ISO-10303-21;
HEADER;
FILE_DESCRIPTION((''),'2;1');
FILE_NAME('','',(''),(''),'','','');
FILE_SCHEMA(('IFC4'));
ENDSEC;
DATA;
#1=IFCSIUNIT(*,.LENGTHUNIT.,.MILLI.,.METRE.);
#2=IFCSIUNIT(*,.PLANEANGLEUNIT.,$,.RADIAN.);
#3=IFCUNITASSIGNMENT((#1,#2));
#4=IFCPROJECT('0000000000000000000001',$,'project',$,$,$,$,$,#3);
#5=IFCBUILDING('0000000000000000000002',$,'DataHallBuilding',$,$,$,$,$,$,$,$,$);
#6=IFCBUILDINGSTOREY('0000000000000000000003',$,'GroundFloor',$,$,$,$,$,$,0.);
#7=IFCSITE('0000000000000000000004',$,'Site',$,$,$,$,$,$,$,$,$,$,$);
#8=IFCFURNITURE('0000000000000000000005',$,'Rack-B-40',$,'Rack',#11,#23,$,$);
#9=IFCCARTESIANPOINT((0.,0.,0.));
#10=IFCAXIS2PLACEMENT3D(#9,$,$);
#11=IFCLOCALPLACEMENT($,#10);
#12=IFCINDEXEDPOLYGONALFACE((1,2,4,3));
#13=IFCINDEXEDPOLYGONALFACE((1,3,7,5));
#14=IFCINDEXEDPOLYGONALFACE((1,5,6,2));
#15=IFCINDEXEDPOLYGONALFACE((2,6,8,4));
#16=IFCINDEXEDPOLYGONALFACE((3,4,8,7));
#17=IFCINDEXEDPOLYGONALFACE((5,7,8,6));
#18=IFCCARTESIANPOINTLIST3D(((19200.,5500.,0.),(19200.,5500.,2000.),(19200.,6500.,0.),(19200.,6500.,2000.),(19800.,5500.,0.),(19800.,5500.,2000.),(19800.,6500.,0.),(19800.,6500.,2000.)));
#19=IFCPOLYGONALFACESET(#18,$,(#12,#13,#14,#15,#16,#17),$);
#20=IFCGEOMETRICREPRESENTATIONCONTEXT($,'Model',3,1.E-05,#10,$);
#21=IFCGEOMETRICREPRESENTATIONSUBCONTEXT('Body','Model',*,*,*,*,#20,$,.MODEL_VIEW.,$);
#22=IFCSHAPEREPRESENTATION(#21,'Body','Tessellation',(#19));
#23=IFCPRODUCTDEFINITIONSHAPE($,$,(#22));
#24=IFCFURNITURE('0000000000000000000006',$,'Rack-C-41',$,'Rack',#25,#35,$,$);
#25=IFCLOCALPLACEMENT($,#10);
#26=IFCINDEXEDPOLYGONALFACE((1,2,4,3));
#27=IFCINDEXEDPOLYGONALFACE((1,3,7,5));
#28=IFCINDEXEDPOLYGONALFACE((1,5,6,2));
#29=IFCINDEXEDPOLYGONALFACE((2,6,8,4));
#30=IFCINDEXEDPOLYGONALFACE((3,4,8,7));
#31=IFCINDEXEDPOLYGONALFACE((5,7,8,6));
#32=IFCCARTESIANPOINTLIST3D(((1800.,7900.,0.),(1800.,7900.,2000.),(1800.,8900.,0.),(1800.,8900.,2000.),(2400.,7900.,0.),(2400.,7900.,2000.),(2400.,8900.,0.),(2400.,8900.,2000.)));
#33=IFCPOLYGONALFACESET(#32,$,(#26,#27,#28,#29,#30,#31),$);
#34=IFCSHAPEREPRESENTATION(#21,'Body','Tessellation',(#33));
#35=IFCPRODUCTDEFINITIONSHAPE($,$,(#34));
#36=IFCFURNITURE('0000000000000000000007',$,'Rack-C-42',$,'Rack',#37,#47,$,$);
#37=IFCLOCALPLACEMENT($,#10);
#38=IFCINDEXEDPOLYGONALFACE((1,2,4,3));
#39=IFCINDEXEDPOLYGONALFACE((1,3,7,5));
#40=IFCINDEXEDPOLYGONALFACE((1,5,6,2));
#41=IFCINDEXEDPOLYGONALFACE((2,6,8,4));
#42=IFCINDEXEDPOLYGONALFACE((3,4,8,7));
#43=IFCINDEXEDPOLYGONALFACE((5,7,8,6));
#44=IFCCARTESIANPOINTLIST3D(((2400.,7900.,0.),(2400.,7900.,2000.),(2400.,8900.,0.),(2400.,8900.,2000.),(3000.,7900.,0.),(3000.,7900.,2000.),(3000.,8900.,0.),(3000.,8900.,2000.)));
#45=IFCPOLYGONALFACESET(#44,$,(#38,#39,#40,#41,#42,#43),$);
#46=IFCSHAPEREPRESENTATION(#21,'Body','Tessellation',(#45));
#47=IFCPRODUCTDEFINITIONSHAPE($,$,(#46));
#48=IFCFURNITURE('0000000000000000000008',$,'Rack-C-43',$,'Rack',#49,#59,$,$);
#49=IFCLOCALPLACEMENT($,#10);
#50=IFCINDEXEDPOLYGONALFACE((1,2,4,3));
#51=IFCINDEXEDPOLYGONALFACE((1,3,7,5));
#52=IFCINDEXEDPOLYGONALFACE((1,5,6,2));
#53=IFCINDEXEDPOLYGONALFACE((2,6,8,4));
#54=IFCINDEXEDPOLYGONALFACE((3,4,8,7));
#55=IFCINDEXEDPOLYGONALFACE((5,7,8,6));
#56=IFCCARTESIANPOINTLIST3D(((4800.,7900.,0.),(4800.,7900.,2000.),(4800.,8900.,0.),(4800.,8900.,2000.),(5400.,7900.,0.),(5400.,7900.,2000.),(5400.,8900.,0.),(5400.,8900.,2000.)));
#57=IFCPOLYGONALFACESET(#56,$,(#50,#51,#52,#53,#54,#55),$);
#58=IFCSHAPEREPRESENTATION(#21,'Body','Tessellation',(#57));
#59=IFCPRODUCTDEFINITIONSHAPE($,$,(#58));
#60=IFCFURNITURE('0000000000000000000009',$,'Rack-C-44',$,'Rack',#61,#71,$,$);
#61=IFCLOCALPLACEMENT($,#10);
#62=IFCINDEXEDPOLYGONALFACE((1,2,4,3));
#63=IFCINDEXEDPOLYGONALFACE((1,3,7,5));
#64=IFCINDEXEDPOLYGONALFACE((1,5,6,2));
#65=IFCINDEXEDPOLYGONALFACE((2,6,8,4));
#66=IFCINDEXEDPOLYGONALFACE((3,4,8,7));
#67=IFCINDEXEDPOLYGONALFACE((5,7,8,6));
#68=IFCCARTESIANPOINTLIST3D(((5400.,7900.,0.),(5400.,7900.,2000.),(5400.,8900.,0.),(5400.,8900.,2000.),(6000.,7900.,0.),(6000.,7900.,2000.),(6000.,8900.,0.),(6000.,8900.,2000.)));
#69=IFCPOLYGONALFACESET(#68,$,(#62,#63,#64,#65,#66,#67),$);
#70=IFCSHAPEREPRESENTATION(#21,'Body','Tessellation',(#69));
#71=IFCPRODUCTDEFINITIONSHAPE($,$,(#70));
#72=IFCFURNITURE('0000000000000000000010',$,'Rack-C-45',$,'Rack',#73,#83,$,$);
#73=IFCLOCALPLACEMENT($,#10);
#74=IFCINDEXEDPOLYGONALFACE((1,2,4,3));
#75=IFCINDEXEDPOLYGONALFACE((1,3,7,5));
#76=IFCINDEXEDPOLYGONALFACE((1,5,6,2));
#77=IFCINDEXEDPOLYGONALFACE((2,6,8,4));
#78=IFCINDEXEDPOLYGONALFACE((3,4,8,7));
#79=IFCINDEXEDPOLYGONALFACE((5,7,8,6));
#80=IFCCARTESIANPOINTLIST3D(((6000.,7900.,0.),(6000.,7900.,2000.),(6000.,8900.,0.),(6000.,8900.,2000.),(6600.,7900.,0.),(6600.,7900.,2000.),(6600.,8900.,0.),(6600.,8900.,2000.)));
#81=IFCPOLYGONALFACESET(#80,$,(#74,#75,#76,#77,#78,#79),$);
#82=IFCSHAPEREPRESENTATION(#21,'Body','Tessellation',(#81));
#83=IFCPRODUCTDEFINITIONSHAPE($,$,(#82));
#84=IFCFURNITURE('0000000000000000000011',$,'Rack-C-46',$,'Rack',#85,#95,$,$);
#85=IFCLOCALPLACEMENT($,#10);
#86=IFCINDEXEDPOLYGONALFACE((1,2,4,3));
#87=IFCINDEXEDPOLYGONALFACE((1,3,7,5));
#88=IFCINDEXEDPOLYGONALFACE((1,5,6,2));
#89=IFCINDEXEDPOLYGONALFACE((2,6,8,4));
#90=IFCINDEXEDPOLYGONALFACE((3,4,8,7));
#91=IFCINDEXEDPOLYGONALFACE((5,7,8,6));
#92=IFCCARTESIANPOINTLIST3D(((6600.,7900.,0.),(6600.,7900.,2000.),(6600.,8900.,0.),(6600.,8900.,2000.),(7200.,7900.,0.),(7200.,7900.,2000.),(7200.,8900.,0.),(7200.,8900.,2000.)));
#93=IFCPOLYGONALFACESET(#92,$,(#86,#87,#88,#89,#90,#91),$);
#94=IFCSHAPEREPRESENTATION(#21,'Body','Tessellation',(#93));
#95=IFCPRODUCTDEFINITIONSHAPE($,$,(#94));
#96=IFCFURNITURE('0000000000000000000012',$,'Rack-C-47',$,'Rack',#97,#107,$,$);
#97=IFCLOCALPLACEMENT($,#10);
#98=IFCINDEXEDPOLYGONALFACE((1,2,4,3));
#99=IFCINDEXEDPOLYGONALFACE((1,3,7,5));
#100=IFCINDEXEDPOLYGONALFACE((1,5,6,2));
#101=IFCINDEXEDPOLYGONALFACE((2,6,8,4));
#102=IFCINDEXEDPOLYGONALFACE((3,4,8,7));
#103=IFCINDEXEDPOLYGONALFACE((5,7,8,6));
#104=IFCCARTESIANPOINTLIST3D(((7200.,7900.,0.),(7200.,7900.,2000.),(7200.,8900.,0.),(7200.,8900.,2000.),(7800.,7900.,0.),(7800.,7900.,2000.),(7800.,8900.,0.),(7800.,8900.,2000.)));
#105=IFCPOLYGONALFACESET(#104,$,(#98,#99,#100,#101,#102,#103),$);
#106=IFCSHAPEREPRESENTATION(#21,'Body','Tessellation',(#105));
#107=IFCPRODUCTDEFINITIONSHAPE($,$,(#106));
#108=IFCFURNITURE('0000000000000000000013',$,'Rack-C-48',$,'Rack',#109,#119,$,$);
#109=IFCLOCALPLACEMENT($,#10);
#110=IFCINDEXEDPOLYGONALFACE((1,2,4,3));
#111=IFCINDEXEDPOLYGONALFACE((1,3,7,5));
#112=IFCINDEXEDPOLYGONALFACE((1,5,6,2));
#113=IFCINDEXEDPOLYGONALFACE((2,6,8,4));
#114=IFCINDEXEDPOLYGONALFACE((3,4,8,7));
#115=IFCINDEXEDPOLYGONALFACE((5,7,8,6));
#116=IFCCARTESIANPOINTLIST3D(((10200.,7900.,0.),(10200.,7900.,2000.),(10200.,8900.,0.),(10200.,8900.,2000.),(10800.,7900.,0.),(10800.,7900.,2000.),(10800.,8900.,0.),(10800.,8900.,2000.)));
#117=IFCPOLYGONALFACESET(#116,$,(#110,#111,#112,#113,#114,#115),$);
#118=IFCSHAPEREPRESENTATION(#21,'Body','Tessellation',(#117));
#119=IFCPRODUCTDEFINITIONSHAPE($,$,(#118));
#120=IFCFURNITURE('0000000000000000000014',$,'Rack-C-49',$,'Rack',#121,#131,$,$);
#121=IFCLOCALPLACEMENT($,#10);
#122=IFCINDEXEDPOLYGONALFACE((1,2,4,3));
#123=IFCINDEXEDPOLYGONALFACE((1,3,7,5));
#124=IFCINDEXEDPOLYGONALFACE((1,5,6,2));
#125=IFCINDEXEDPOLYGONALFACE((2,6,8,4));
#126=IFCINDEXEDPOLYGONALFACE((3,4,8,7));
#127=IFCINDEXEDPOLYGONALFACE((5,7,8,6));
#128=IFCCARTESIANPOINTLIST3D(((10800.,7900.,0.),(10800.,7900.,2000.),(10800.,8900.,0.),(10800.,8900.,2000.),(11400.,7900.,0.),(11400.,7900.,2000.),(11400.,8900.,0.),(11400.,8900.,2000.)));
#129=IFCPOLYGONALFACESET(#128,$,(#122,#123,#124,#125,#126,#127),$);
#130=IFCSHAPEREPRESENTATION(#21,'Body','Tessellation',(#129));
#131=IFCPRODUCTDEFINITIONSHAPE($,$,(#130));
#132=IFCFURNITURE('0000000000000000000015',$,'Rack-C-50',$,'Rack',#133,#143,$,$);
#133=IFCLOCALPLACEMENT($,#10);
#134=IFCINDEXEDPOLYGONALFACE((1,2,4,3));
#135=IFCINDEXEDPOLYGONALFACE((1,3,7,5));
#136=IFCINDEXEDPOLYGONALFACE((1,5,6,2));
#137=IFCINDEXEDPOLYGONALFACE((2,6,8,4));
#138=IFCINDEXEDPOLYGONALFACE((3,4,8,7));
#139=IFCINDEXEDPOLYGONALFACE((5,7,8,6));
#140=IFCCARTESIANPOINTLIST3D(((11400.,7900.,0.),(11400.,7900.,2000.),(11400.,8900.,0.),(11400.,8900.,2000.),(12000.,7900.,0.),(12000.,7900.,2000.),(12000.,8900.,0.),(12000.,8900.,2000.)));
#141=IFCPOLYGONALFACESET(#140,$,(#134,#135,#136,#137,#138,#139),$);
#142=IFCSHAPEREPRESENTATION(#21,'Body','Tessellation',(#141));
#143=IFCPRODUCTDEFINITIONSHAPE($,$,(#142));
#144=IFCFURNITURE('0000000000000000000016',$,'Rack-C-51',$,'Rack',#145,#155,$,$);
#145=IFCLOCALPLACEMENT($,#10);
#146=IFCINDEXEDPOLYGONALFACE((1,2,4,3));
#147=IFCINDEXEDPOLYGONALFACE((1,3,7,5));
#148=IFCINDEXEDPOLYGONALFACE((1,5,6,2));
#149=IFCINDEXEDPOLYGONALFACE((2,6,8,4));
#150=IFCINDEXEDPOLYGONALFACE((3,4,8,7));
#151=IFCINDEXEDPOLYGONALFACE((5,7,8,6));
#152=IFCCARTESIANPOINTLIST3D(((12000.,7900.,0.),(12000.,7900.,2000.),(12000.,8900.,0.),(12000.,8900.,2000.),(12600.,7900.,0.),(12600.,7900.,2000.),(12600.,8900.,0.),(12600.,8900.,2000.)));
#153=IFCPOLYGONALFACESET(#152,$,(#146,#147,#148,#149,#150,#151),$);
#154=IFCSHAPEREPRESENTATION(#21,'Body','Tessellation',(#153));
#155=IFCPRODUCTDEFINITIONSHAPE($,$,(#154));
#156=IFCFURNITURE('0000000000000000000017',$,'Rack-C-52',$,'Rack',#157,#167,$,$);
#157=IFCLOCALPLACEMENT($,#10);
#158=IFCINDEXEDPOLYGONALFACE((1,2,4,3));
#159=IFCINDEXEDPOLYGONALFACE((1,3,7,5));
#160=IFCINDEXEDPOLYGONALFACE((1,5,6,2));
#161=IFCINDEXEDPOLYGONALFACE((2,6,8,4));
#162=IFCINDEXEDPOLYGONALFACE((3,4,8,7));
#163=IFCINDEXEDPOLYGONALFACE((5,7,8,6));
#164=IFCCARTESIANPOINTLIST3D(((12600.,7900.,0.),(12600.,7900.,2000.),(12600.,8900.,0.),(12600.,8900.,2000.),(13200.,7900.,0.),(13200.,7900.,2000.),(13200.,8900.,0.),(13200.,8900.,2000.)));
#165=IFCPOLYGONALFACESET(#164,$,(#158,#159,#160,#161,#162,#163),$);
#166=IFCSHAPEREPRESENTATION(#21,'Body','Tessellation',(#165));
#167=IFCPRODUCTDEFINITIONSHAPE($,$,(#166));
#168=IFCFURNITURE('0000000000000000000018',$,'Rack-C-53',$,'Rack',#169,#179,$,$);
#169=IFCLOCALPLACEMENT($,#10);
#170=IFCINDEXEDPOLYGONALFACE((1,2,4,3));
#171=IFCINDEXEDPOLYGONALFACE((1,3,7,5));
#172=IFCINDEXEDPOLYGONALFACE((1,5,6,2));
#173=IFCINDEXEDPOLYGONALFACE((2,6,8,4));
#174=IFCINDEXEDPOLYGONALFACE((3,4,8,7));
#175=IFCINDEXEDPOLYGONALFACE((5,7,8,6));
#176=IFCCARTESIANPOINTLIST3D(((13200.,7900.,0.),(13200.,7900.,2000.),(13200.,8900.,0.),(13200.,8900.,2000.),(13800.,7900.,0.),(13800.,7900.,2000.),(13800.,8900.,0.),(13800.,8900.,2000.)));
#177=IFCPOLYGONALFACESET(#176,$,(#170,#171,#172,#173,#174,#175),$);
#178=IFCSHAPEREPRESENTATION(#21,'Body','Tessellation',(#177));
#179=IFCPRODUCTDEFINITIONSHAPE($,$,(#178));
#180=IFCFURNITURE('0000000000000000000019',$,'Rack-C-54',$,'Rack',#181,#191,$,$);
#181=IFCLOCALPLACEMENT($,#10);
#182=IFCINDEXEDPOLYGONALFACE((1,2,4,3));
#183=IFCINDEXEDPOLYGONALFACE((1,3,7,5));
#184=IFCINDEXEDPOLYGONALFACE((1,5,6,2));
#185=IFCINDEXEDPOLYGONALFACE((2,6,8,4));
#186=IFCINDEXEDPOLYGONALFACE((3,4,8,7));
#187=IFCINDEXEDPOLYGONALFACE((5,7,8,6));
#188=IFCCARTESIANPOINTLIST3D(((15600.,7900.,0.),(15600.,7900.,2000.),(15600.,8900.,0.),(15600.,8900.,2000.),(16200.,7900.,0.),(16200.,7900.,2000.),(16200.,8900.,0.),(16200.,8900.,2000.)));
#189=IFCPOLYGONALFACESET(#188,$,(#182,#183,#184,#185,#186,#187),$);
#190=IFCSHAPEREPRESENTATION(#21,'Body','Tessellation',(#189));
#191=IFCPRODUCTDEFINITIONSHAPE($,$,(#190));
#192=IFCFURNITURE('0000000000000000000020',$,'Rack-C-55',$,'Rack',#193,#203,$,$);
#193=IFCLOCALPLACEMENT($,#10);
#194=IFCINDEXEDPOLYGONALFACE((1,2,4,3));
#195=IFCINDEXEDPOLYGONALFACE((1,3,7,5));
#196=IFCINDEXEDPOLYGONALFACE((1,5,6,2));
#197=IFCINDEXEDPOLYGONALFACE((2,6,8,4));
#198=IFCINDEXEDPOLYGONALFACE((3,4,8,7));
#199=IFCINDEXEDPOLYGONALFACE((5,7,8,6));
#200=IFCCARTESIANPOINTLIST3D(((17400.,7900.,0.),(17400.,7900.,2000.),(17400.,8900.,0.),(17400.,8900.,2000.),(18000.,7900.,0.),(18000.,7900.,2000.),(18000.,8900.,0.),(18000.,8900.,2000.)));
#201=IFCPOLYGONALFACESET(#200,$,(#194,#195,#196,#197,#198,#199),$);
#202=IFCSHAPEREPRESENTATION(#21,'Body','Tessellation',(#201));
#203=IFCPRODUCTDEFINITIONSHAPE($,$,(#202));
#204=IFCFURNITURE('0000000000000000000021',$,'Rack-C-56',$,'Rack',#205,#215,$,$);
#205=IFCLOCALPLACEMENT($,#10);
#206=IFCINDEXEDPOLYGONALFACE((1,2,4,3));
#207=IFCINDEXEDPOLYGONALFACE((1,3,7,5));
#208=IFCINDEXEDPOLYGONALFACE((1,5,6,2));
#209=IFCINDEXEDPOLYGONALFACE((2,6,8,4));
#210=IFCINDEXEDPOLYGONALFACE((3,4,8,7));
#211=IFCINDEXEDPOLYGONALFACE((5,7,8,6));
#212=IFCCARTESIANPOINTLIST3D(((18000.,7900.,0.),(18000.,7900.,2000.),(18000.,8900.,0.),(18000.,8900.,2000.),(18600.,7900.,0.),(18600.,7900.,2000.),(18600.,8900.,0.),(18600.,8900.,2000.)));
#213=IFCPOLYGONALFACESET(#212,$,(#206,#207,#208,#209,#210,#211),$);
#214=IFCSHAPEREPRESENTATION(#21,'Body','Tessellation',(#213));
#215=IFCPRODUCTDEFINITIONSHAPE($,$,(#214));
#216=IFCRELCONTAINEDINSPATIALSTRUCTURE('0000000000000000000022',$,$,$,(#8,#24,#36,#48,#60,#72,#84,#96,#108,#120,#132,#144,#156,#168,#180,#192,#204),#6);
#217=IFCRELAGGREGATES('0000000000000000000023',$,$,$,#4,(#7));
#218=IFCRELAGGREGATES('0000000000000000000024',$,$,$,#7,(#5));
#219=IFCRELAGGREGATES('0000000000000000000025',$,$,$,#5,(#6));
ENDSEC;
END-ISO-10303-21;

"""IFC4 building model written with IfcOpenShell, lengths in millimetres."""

from ifc_helpers import new_model, si_unit, frame, origin, place, context, subcontext, project, spatial, rectangle, extrude, element, save


model = new_model("IFC4")

# Units and contexts
model_context = context("Model", 3, precision=1e-05, world=origin())
body_context = subcontext(model_context, "Body", "Model", "MODEL_VIEW")
ifc_project = project(units=[si_unit("LENGTHUNIT", "METRE", prefix="MILLI"), si_unit("PLANEANGLEUNIT", "RADIAN")])

# Site, building, storey
site = spatial("IfcSite", under=ifc_project, Name="Site")
building = spatial("IfcBuilding", under=site, Name="DataHallBuilding")
storey = spatial("IfcBuildingStorey", under=building, Name="GroundFloor", Elevation=0.0)

# Furniture
furniture_1_placement = place(None, origin())
element("IfcFurniture", 1, at=furniture_1_placement, inside=storey, Name="Rack-B-40", ObjectType="Rack", context=body_context, shape_type="SweptSolid", body=[
    extrude(rectangle(XDim=600.0, YDim=1000.0), frame((19500.0, 6000.0, 0.0), z_axis=(0.0, 0.0, 1.0), x_axis=(1.0, 0.0, 0.0)), (0.0, 0.0, 1.0), 2000.0),
])
furniture_2_placement = place(None, origin())
element("IfcFurniture", 2, at=furniture_2_placement, inside=storey, Name="Rack-C-41", ObjectType="Rack", context=body_context, shape_type="SweptSolid", body=[
    extrude(rectangle(XDim=600.0, YDim=1000.0), frame((2100.0, 8400.0, 0.0), z_axis=(0.0, 0.0, 1.0), x_axis=(1.0, 0.0, 0.0)), (0.0, 0.0, 1.0), 2000.0),
])
furniture_3_placement = place(None, origin())
element("IfcFurniture", 3, at=furniture_3_placement, inside=storey, Name="Rack-C-42", ObjectType="Rack", context=body_context, shape_type="SweptSolid", body=[
    extrude(rectangle(XDim=600.0, YDim=1000.0), frame((2700.0, 8400.0, 0.0), z_axis=(0.0, 0.0, 1.0), x_axis=(1.0, 0.0, 0.0)), (0.0, 0.0, 1.0), 2000.0),
])
furniture_4_placement = place(None, origin())
element("IfcFurniture", 4, at=furniture_4_placement, inside=storey, Name="Rack-C-43", ObjectType="Rack", context=body_context, shape_type="SweptSolid", body=[
    extrude(rectangle(XDim=600.0, YDim=1000.0), frame((5100.0, 8400.0, 0.0), z_axis=(0.0, 0.0, 1.0), x_axis=(1.0, 0.0, 0.0)), (0.0, 0.0, 1.0), 2000.0),
])
furniture_5_placement = place(None, origin())
element("IfcFurniture", 5, at=furniture_5_placement, inside=storey, Name="Rack-C-44", ObjectType="Rack", context=body_context, shape_type="SweptSolid", body=[
    extrude(rectangle(XDim=600.0, YDim=1000.0), frame((5700.0, 8400.0, 0.0), z_axis=(0.0, 0.0, 1.0), x_axis=(1.0, 0.0, 0.0)), (0.0, 0.0, 1.0), 2000.0),
])
furniture_6_placement = place(None, origin())
element("IfcFurniture", 6, at=furniture_6_placement, inside=storey, Name="Rack-C-45", ObjectType="Rack", context=body_context, shape_type="SweptSolid", body=[
    extrude(rectangle(XDim=600.0, YDim=1000.0), frame((6300.0, 8400.0, 0.0), z_axis=(0.0, 0.0, 1.0), x_axis=(1.0, 0.0, 0.0)), (0.0, 0.0, 1.0), 2000.0),
])
furniture_7_placement = place(None, origin())
element("IfcFurniture", 7, at=furniture_7_placement, inside=storey, Name="Rack-C-46", ObjectType="Rack", context=body_context, shape_type="SweptSolid", body=[
    extrude(rectangle(XDim=600.0, YDim=1000.0), frame((6900.0, 8400.0, 0.0), z_axis=(0.0, 0.0, 1.0), x_axis=(1.0, 0.0, 0.0)), (0.0, 0.0, 1.0), 2000.0),
])
furniture_8_placement = place(None, origin())
element("IfcFurniture", 8, at=furniture_8_placement, inside=storey, Name="Rack-C-47", ObjectType="Rack", context=body_context, shape_type="SweptSolid", body=[
    extrude(rectangle(XDim=600.0, YDim=1000.0), frame((7500.0, 8400.0, 0.0), z_axis=(0.0, 0.0, 1.0), x_axis=(1.0, 0.0, 0.0)), (0.0, 0.0, 1.0), 2000.0),
])
furniture_9_placement = place(None, origin())
element("IfcFurniture", 9, at=furniture_9_placement, inside=storey, Name="Rack-C-48", ObjectType="Rack", context=body_context, shape_type="SweptSolid", body=[
    extrude(rectangle(XDim=600.0, YDim=1000.0), frame((10500.0, 8400.0, 0.0), z_axis=(0.0, 0.0, 1.0), x_axis=(1.0, 0.0, 0.0)), (0.0, 0.0, 1.0), 2000.0),
])
furniture_10_placement = place(None, origin())
element("IfcFurniture", 10, at=furniture_10_placement, inside=storey, Name="Rack-C-49", ObjectType="Rack", context=body_context, shape_type="SweptSolid", body=[
    extrude(rectangle(XDim=600.0, YDim=1000.0), frame((11100.0, 8400.0, 0.0), z_axis=(0.0, 0.0, 1.0), x_axis=(1.0, 0.0, 0.0)), (0.0, 0.0, 1.0), 2000.0),
])
furniture_11_placement = place(None, origin())
element("IfcFurniture", 11, at=furniture_11_placement, inside=storey, Name="Rack-C-50", ObjectType="Rack", context=body_context, shape_type="SweptSolid", body=[
    extrude(rectangle(XDim=600.0, YDim=1000.0), frame((11700.0, 8400.0, 0.0), z_axis=(0.0, 0.0, 1.0), x_axis=(1.0, 0.0, 0.0)), (0.0, 0.0, 1.0), 2000.0),
])
furniture_12_placement = place(None, origin())
element("IfcFurniture", 12, at=furniture_12_placement, inside=storey, Name="Rack-C-51", ObjectType="Rack", context=body_context, shape_type="SweptSolid", body=[
    extrude(rectangle(XDim=600.0, YDim=1000.0), frame((12300.0, 8400.0, 0.0), z_axis=(0.0, 0.0, 1.0), x_axis=(1.0, 0.0, 0.0)), (0.0, 0.0, 1.0), 2000.0),
])
furniture_13_placement = place(None, origin())
element("IfcFurniture", 13, at=furniture_13_placement, inside=storey, Name="Rack-C-52", ObjectType="Rack", context=body_context, shape_type="SweptSolid", body=[
    extrude(rectangle(XDim=600.0, YDim=1000.0), frame((12900.0, 8400.0, 0.0), z_axis=(0.0, 0.0, 1.0), x_axis=(1.0, 0.0, 0.0)), (0.0, 0.0, 1.0), 2000.0),
])
furniture_14_placement = place(None, origin())
element("IfcFurniture", 14, at=furniture_14_placement, inside=storey, Name="Rack-C-53", ObjectType="Rack", context=body_context, shape_type="SweptSolid", body=[
    extrude(rectangle(XDim=600.0, YDim=1000.0), frame((13500.0, 8400.0, 0.0), z_axis=(0.0, 0.0, 1.0), x_axis=(1.0, 0.0, 0.0)), (0.0, 0.0, 1.0), 2000.0),
])
furniture_15_placement = place(None, origin())
element("IfcFurniture", 15, at=furniture_15_placement, inside=storey, Name="Rack-C-54", ObjectType="Rack", context=body_context, shape_type="SweptSolid", body=[
    extrude(rectangle(XDim=600.0, YDim=1000.0), frame((15900.0, 8400.0, 0.0), z_axis=(0.0, 0.0, 1.0), x_axis=(1.0, 0.0, 0.0)), (0.0, 0.0, 1.0), 2000.0),
])
furniture_16_placement = place(None, origin())
element("IfcFurniture", 16, at=furniture_16_placement, inside=storey, Name="Rack-C-55", ObjectType="Rack", context=body_context, shape_type="SweptSolid", body=[
    extrude(rectangle(XDim=600.0, YDim=1000.0), frame((17700.0, 8400.0, 0.0), z_axis=(0.0, 0.0, 1.0), x_axis=(1.0, 0.0, 0.0)), (0.0, 0.0, 1.0), 2000.0),
])
furniture_17_placement = place(None, origin())
element("IfcFurniture", 17, at=furniture_17_placement, inside=storey, Name="Rack-C-56", ObjectType="Rack", context=body_context, shape_type="SweptSolid", body=[
    extrude(rectangle(XDim=600.0, YDim=1000.0), frame((18300.0, 8400.0, 0.0), z_axis=(0.0, 0.0, 1.0), x_axis=(1.0, 0.0, 0.0)), (0.0, 0.0, 1.0), 2000.0),
])

save(model, "model.ifc")
